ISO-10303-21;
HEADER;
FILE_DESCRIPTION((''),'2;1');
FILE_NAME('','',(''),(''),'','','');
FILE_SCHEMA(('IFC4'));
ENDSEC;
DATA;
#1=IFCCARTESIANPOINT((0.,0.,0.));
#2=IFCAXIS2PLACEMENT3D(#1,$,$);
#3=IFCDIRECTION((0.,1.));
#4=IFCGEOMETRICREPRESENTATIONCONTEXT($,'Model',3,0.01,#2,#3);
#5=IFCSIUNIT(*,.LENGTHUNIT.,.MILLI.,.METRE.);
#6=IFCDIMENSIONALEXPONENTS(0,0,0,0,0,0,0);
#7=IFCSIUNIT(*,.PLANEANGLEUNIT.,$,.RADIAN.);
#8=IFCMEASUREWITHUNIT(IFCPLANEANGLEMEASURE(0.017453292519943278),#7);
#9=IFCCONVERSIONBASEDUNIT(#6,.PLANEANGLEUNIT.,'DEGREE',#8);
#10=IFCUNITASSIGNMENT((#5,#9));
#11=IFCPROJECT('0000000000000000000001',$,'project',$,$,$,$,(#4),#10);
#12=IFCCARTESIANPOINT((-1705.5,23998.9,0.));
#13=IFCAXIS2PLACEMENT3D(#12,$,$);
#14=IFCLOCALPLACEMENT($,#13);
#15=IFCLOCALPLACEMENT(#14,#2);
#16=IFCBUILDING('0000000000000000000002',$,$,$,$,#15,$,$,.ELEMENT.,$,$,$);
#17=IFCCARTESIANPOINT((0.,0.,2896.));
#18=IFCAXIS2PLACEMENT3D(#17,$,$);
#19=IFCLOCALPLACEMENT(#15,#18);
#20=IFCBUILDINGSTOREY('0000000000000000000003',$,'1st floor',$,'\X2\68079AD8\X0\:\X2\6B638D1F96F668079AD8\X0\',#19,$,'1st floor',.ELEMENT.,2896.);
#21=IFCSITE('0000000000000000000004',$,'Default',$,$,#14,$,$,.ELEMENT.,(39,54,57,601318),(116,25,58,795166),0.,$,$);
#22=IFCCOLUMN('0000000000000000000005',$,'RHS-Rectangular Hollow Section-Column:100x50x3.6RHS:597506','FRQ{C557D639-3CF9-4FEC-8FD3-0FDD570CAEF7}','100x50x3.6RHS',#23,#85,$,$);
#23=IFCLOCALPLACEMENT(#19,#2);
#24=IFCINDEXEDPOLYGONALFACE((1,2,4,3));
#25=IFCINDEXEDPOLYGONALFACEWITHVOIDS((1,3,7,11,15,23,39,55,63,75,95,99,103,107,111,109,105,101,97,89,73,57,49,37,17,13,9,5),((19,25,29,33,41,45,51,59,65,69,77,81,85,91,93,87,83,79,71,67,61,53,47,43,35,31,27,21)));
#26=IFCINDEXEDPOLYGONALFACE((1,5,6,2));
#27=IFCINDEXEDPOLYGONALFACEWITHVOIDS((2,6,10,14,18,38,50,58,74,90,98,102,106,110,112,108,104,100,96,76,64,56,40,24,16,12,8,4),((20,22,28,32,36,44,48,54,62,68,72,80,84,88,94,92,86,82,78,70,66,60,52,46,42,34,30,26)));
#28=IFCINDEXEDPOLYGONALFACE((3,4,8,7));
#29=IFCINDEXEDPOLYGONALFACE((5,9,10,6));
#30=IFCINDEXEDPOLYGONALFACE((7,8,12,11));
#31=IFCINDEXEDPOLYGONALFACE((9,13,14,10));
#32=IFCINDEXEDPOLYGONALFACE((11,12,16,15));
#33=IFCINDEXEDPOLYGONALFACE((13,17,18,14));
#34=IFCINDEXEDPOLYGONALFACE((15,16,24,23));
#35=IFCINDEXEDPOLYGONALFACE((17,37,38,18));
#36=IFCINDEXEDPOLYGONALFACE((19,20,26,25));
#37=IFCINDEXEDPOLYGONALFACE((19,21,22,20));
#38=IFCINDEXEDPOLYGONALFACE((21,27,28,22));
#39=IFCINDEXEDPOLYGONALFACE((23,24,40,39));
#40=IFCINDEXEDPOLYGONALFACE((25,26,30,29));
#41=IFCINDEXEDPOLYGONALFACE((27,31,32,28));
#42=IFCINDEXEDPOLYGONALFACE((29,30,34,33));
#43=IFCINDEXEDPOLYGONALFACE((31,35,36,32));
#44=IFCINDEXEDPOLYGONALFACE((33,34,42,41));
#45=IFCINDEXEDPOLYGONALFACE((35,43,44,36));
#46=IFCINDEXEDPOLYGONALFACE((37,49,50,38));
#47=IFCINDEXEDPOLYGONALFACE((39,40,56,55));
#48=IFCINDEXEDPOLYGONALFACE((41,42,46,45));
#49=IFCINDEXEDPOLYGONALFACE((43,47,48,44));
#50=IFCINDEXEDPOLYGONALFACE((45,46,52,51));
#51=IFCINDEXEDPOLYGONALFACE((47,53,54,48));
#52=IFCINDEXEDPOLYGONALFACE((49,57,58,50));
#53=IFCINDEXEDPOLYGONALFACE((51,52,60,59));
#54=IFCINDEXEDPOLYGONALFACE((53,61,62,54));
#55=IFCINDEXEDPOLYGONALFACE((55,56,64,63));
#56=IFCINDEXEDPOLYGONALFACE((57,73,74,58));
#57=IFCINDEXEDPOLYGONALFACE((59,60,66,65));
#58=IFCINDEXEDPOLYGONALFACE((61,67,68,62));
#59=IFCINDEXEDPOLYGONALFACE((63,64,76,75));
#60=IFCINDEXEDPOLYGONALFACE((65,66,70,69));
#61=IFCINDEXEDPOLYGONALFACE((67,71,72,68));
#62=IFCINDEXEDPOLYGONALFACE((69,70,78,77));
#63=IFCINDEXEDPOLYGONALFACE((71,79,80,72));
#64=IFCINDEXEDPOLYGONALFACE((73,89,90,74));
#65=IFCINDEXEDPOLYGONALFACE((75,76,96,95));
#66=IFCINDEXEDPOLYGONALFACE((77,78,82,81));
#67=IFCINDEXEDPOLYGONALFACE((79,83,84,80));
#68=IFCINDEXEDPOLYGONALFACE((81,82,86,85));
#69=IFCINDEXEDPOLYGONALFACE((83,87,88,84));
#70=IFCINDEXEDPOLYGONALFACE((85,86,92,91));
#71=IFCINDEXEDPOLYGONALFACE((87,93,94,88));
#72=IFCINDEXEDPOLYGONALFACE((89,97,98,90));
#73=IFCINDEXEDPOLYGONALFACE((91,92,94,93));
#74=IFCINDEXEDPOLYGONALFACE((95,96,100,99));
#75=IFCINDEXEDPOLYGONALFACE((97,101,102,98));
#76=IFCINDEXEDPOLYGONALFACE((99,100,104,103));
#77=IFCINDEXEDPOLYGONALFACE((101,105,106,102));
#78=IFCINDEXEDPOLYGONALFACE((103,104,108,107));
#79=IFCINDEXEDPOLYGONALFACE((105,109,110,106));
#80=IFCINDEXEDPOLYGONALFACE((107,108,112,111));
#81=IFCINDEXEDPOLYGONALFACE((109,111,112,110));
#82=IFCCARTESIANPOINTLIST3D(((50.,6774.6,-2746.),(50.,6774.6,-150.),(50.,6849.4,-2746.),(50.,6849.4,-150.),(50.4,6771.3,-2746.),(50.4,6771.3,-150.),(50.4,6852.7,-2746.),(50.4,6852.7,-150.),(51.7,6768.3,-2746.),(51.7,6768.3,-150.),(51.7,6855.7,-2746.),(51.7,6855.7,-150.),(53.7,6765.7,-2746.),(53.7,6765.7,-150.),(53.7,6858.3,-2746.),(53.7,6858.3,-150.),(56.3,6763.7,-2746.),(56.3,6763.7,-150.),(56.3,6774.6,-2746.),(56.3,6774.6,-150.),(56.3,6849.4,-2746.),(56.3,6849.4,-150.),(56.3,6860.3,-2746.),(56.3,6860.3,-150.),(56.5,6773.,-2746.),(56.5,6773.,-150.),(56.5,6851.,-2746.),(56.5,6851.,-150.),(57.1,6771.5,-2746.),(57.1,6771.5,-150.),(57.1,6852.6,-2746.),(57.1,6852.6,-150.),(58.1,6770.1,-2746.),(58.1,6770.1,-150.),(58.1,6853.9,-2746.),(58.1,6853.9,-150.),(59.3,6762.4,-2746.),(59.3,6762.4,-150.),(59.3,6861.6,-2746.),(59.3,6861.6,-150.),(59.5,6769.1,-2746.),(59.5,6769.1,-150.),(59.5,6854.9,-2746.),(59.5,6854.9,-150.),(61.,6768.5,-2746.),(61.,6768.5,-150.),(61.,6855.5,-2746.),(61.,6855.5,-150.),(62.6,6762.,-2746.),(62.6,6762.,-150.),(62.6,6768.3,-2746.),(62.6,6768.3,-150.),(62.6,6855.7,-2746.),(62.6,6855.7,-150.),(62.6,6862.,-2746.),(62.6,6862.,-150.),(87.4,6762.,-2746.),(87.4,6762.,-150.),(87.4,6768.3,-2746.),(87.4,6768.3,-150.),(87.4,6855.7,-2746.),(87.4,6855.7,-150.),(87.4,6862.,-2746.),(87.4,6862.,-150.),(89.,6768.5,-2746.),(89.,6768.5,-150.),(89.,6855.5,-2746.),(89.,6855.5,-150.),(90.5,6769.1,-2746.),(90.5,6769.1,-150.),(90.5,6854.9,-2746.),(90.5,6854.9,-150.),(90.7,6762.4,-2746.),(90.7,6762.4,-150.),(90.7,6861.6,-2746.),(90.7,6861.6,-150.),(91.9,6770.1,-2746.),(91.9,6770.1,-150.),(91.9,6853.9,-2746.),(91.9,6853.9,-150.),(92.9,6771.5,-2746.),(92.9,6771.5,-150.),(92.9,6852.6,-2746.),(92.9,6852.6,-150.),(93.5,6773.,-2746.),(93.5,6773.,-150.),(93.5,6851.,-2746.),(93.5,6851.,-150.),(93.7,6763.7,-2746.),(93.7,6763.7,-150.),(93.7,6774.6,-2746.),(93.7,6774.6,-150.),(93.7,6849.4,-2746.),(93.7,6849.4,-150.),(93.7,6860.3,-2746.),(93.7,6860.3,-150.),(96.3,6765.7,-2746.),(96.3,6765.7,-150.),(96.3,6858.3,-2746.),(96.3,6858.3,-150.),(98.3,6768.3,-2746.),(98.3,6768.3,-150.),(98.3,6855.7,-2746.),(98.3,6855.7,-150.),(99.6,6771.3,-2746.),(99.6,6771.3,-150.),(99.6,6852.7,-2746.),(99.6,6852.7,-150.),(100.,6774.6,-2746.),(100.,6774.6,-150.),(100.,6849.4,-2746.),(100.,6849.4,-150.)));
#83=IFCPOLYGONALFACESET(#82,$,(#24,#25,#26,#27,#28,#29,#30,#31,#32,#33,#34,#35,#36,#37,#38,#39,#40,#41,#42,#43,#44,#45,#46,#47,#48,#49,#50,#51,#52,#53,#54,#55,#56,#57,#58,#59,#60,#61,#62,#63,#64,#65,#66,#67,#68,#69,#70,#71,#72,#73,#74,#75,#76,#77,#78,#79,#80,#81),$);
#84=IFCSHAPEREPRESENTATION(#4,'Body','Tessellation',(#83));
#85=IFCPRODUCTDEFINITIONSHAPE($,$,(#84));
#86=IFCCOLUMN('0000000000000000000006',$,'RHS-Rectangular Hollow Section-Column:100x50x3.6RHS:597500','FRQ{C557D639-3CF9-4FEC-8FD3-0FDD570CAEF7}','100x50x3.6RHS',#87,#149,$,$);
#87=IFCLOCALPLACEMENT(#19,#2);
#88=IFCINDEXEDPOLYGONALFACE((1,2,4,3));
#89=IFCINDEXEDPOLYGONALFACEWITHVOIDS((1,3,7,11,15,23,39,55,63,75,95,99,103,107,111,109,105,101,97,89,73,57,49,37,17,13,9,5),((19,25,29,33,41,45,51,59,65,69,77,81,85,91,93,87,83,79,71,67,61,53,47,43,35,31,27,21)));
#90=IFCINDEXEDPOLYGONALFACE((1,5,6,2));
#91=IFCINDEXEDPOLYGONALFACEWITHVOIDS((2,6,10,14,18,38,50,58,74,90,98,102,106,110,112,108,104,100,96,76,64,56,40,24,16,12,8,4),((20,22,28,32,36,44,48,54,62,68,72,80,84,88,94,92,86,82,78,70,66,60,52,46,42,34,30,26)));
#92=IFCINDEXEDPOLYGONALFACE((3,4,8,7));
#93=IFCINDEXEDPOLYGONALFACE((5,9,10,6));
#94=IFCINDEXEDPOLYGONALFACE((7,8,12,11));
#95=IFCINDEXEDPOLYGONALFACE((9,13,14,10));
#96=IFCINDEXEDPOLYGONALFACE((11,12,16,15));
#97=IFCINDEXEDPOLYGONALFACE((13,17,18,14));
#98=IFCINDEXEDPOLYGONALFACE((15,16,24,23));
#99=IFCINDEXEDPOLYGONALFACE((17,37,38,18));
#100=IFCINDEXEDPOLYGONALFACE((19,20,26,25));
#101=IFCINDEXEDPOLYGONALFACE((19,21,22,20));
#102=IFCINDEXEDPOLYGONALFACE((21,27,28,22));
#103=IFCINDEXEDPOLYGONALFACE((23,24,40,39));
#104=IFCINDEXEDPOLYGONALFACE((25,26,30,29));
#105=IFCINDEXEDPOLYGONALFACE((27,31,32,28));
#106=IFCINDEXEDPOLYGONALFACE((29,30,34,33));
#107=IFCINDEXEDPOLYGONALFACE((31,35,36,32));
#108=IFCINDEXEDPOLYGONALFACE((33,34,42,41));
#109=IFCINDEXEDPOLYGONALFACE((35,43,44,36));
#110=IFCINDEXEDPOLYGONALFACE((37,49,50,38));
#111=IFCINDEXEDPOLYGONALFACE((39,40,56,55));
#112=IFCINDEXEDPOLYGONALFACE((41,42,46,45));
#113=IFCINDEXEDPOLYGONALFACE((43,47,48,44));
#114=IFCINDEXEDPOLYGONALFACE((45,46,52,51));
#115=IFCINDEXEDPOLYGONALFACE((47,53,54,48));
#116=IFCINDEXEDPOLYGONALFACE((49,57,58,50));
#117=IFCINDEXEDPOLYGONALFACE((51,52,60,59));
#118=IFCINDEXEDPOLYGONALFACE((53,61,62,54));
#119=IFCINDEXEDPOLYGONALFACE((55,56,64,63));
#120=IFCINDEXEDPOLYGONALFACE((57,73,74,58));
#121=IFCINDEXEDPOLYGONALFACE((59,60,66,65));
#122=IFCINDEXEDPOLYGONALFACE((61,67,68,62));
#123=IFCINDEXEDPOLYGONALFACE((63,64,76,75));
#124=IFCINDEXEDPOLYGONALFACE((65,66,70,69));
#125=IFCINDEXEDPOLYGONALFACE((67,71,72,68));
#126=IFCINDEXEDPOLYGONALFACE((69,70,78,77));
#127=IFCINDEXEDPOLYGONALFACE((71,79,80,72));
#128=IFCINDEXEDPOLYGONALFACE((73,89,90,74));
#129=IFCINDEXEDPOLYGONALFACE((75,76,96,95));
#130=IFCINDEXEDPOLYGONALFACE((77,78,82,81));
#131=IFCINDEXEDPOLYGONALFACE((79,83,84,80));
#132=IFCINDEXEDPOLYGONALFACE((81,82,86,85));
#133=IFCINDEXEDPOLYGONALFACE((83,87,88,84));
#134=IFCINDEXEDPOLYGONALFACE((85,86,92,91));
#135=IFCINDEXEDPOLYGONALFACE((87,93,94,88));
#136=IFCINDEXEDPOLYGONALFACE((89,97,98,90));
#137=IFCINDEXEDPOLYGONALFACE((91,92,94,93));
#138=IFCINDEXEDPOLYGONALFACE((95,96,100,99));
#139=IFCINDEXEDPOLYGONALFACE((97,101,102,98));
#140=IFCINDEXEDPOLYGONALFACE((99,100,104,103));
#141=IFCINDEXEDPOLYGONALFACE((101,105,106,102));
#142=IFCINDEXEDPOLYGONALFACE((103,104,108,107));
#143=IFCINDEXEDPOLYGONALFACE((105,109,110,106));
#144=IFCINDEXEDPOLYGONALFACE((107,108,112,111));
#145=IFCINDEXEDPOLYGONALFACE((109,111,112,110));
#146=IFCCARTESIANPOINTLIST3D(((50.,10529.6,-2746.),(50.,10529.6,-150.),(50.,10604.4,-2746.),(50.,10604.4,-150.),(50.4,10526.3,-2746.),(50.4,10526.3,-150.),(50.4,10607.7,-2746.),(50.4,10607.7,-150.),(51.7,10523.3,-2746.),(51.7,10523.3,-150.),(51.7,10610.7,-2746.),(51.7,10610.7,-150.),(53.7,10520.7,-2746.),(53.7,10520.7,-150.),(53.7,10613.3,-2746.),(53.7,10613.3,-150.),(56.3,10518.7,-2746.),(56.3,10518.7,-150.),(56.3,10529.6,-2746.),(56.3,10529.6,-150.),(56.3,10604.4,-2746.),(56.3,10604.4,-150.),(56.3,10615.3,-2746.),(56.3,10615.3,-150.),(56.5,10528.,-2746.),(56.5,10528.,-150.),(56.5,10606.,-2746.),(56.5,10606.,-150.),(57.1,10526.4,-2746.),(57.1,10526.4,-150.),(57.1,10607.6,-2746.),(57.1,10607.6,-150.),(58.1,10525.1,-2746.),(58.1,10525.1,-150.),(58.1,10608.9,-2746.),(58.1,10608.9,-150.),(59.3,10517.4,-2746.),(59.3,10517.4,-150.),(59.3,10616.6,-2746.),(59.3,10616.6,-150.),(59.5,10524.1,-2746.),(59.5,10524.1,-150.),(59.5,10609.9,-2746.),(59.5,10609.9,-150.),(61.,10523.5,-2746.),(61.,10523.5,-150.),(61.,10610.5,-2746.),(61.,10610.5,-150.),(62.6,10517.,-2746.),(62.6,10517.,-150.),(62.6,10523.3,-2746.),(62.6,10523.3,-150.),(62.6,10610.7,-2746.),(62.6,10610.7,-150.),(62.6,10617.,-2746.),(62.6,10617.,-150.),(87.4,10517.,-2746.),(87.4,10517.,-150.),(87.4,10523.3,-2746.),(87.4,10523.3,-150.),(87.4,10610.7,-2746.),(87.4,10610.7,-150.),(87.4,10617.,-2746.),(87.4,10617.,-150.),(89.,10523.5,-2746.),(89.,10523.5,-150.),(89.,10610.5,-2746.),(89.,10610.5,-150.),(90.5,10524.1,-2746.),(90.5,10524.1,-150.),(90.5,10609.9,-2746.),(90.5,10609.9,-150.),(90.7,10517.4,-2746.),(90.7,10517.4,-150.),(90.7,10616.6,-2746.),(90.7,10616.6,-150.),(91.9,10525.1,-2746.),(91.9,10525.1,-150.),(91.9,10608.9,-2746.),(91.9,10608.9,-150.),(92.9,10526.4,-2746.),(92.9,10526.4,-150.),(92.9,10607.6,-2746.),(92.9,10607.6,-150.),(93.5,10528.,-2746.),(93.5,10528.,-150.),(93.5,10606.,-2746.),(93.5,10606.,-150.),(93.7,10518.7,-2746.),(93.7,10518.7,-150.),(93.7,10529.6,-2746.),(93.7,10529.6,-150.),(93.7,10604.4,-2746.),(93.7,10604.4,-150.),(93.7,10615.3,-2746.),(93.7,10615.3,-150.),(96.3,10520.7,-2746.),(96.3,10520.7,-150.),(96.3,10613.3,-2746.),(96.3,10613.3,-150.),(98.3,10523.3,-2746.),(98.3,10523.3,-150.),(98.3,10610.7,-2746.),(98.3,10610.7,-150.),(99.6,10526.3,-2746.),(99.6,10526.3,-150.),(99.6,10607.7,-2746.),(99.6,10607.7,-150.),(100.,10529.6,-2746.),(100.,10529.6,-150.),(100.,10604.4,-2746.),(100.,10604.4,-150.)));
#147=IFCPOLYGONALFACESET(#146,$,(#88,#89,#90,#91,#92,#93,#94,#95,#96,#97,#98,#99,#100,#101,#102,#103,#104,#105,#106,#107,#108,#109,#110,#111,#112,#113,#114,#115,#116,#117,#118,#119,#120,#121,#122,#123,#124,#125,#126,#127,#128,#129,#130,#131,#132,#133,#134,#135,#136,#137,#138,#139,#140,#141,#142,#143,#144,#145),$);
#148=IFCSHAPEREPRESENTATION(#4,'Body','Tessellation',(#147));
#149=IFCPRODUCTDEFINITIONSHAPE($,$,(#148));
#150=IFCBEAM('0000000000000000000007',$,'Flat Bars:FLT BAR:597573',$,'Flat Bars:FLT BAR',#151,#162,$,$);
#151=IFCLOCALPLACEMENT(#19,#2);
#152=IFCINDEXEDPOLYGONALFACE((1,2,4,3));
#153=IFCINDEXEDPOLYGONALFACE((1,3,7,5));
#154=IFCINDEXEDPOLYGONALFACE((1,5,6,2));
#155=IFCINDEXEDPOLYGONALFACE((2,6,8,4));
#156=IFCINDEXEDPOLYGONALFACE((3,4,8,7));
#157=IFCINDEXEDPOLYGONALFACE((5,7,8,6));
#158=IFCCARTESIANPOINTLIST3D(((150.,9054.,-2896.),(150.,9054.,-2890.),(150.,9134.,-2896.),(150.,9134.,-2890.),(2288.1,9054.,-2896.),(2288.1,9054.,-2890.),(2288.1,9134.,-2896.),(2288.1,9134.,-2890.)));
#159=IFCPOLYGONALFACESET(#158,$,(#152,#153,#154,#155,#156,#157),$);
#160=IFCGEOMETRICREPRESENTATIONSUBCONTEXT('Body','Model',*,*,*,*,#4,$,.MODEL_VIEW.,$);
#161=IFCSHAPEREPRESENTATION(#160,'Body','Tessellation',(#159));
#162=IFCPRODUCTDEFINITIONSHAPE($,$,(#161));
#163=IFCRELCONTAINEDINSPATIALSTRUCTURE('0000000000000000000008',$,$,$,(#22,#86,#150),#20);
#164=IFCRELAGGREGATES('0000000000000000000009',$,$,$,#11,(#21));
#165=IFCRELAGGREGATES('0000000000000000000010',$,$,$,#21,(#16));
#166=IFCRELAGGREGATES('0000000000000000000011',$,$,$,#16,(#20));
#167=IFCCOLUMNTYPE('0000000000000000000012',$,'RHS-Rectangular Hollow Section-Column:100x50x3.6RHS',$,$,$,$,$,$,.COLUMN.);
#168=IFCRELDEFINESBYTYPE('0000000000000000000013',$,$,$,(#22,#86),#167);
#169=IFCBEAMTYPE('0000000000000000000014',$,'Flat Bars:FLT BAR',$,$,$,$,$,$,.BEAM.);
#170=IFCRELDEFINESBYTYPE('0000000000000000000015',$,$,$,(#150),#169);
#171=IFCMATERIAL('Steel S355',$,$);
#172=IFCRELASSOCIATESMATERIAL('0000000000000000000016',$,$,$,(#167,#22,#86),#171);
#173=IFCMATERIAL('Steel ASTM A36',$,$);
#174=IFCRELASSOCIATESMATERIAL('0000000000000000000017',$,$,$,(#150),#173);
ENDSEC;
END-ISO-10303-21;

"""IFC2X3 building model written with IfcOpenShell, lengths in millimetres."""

from ifc_helpers import new_model, entity, si_unit, converted_unit, point, direction, frame, frame_2d, origin, origin_2d, origin_2d_with_axis, place, context, subcontext, project, spatial, circle_curve, line_curve, trimmed, segment, composite_curve, rectangle, hollow_rectangle, outline, extrude, clip, halfspace, material, type_object, element, save


model = new_model("IFC2X3")

# Units and contexts
model_context = context("Model", 3, precision=0.01, world=origin(), true_north=direction((0.0, 1.0)))
body_context = subcontext(model_context, "Body", "Model", "MODEL_VIEW")
ifc_project = project(units=[si_unit("LENGTHUNIT", "METRE", prefix="MILLI"), converted_unit("PLANEANGLEUNIT", "DEGREE", entity("IfcPlaneAngleMeasure", 0.017453292519943278), si_unit("PLANEANGLEUNIT", "RADIAN"), dimensions=[0, 0, 0, 0, 0, 0, 0])], contexts=[model_context])

# Site, building, storey
site_placement = place(None, frame((-1705.5, 23998.9, 0.0)))
site = spatial("IfcSite", under=ifc_project, at=site_placement, Name="Default", CompositionType="ELEMENT", RefLatitude=(39, 54, 57, 601318), RefLongitude=(116, 25, 58, 795166), RefElevation=0.0)
building_placement = place(site_placement, origin())
building = spatial("IfcBuilding", under=site, at=building_placement, CompositionType="ELEMENT")
storey_placement = place(building_placement, frame((0.0, 0.0, 2896.0)))
storey = spatial("IfcBuildingStorey", under=building, at=storey_placement, Name="1st floor", ObjectType="标高:正负零标高", LongName="1st floor", CompositionType="ELEMENT", Elevation=2896.0)

# Shared definitions
ifc_material_1 = material(Name="Steel S355")

# Columns, openings
column_type_1 = type_object("IfcColumnType", Name="RHS-Rectangular Hollow Section-Column:100x50x3.6RHS", PredefinedType="COLUMN", material=ifc_material_1)
column_1_placement = place(storey_placement, frame((75.0, 6812.0, -19.1)))
column_1 = element("IfcColumn", 1, at=column_1_placement, inside=storey, type_object=column_type_1, material=ifc_material_1, Name="RHS-Rectangular Hollow Section-Column:100x50x3.6RHS:597506", Description="FRQ{C557D639-3CF9-4FEC-8FD3-0FDD570CAEF7}", ObjectType="100x50x3.6RHS", context=model_context, shape_type="Clipping", body=[
    clip(clip(extrude(hollow_rectangle(XDim=50.0, YDim=100.0, WallThickness=6.3, InnerFilletRadius=6.3, OuterFilletRadius=12.6, at=origin_2d()), origin(), (0.0, 0.0, -1.0), 2782.8), halfspace(frame((-75.0, -6812.0, -2726.9), z_axis=(0.0, 0.0, 1.0), x_axis=(1.0, 0.0, 0.0)), True)), halfspace(frame((-75.0, -6812.0, -55.9), z_axis=(0.0, 0.0, -1.0), x_axis=(-1.0, 0.0, 0.0)), True)),
])
opening_1_placement = place(column_1_placement, frame((0.0, -150.1, -130.9), z_axis=(0.0, 1.0, 0.0), x_axis=(-1.0, 0.0, 0.0)))
element("IfcOpeningElement", 2, at=opening_1_placement, cuts=column_1, ObjectType="Opening", context=model_context, shape_type="SweptSolid", body=[
    extrude(outline(composite_curve([segment(trimmed(circle_curve(frame_2d((43.0, 32.0), x_axis=(1.0, 0.0)), 32.0), [point((43.0, 0.0))], [point((75.0, 32.0))], True, "CARTESIAN"), True, "CONTINUOUS"), segment(trimmed(line_curve((75.0, 32.0), (0.0, 1.0), 86.0), [point((75.0, 32.0))], [point((75.0, 118.0))], True, "CARTESIAN"), True, "CONTINUOUS"), segment(trimmed(circle_curve(frame_2d((43.0, 118.0), x_axis=(1.0, 0.0)), 32.0), [point((75.0, 118.0))], [point((43.0, 150.0))], True, "CARTESIAN"), True, "CONTINUOUS"), segment(trimmed(line_curve((43.0, 150.0), (-1.0, 0.0), 86.0), [point((43.0, 150.0))], [point((-43.0, 150.0))], True, "CARTESIAN"), True, "CONTINUOUS"), segment(trimmed(circle_curve(frame_2d((-43.0, 118.0), x_axis=(1.0, 0.0)), 32.0), [point((-43.0, 150.0))], [point((-75.0, 118.0))], True, "CARTESIAN"), True, "CONTINUOUS"), segment(trimmed(line_curve((-75.0, 118.0), (0.0, -1.0), 86.0), [point((-75.0, 118.0))], [point((-75.0, 32.0))], True, "CARTESIAN"), True, "CONTINUOUS"), segment(trimmed(circle_curve(frame_2d((-43.0, 32.0), x_axis=(1.0, 0.0)), 32.0), [point((-75.0, 32.0))], [point((-43.0, 0.0))], True, "CARTESIAN"), True, "CONTINUOUS"), segment(trimmed(line_curve((-43.0, 0.0), (1.0, 0.0), 86.0), [point((-43.0, 0.0))], [point((43.0, 0.0))], True, "CARTESIAN"), True, "CONTINUOUS")], self_intersect="UNKNOWN")), origin(), (0.0, 0.0, 1.0), 300.2),
])
column_2_placement = place(storey_placement, frame((75.0, 10567.0, -19.1)))
column_2 = element("IfcColumn", 3, at=column_2_placement, inside=storey, type_object=column_type_1, material=ifc_material_1, Name="RHS-Rectangular Hollow Section-Column:100x50x3.6RHS:597500", Description="FRQ{C557D639-3CF9-4FEC-8FD3-0FDD570CAEF7}", ObjectType="100x50x3.6RHS", context=model_context, shape_type="Clipping", body=[
    clip(clip(extrude(hollow_rectangle(XDim=50.0, YDim=100.0, WallThickness=6.3, InnerFilletRadius=6.3, OuterFilletRadius=12.6, at=origin_2d()), origin(), (0.0, 0.0, -1.0), 2782.8), halfspace(frame((-75.0, -10567.0, -55.9), z_axis=(0.0, 0.0, -1.0), x_axis=(-1.0, 0.0, 0.0)), True)), halfspace(frame((-75.0, -10567.0, -2726.9), z_axis=(0.0, 0.0, 1.0), x_axis=(1.0, 0.0, 0.0)), True)),
])
opening_2_placement = place(column_2_placement, frame((0.0, -150.1, -130.9), z_axis=(0.0, 1.0, 0.0), x_axis=(-1.0, 0.0, 0.0)))
element("IfcOpeningElement", 4, at=opening_2_placement, cuts=column_2, ObjectType="Opening", context=model_context, shape_type="SweptSolid", body=[
    extrude(outline(composite_curve([segment(trimmed(circle_curve(frame_2d((43.0, 32.0), x_axis=(1.0, 0.0)), 32.0), [point((43.0, 0.0))], [point((75.0, 32.0))], True, "CARTESIAN"), True, "CONTINUOUS"), segment(trimmed(line_curve((75.0, 32.0), (0.0, 1.0), 86.0), [point((75.0, 32.0))], [point((75.0, 118.0))], True, "CARTESIAN"), True, "CONTINUOUS"), segment(trimmed(circle_curve(frame_2d((43.0, 118.0), x_axis=(1.0, 0.0)), 32.0), [point((75.0, 118.0))], [point((43.0, 150.0))], True, "CARTESIAN"), True, "CONTINUOUS"), segment(trimmed(line_curve((43.0, 150.0), (-1.0, 0.0), 86.0), [point((43.0, 150.0))], [point((-43.0, 150.0))], True, "CARTESIAN"), True, "CONTINUOUS"), segment(trimmed(circle_curve(frame_2d((-43.0, 118.0), x_axis=(1.0, 0.0)), 32.0), [point((-43.0, 150.0))], [point((-75.0, 118.0))], True, "CARTESIAN"), True, "CONTINUOUS"), segment(trimmed(line_curve((-75.0, 118.0), (0.0, -1.0), 86.0), [point((-75.0, 118.0))], [point((-75.0, 32.0))], True, "CARTESIAN"), True, "CONTINUOUS"), segment(trimmed(circle_curve(frame_2d((-43.0, 32.0), x_axis=(1.0, 0.0)), 32.0), [point((-75.0, 32.0))], [point((-43.0, 0.0))], True, "CARTESIAN"), True, "CONTINUOUS"), segment(trimmed(line_curve((-43.0, 0.0), (1.0, 0.0), 86.0), [point((-43.0, 0.0))], [point((43.0, 0.0))], True, "CARTESIAN"), True, "CONTINUOUS")], self_intersect="UNKNOWN")), origin(), (0.0, 0.0, 1.0), 300.2),
])

# Beam
ifc_material_2 = material(Name="Steel ASTM A36")
beam_type_1 = type_object("IfcBeamType", Name="Flat Bars:FLT BAR", PredefinedType="BEAM")
for number, where, name in (
    (5, (150.0, 9094.0, -2890.0), "Flat Bars:FLT BAR:597573"),
):
    element("IfcBeam", number, at=place(storey_placement, frame(where)), inside=storey, type_object=beam_type_1, material=ifc_material_2, Name=name, ObjectType="Flat Bars:FLT BAR", context=body_context, shape_type="SweptSolid", body=[
        extrude(rectangle(XDim=6.0, YDim=80.0, at=origin_2d_with_axis()), frame((0.0, 0.0, -3.0), z_axis=(1.0, 0.0, 0.0), x_axis=(0.0, 0.0, -1.0)), (0.0, 0.0, 1.0), 2138.1),
    ])

save(model, "model.ifc")
